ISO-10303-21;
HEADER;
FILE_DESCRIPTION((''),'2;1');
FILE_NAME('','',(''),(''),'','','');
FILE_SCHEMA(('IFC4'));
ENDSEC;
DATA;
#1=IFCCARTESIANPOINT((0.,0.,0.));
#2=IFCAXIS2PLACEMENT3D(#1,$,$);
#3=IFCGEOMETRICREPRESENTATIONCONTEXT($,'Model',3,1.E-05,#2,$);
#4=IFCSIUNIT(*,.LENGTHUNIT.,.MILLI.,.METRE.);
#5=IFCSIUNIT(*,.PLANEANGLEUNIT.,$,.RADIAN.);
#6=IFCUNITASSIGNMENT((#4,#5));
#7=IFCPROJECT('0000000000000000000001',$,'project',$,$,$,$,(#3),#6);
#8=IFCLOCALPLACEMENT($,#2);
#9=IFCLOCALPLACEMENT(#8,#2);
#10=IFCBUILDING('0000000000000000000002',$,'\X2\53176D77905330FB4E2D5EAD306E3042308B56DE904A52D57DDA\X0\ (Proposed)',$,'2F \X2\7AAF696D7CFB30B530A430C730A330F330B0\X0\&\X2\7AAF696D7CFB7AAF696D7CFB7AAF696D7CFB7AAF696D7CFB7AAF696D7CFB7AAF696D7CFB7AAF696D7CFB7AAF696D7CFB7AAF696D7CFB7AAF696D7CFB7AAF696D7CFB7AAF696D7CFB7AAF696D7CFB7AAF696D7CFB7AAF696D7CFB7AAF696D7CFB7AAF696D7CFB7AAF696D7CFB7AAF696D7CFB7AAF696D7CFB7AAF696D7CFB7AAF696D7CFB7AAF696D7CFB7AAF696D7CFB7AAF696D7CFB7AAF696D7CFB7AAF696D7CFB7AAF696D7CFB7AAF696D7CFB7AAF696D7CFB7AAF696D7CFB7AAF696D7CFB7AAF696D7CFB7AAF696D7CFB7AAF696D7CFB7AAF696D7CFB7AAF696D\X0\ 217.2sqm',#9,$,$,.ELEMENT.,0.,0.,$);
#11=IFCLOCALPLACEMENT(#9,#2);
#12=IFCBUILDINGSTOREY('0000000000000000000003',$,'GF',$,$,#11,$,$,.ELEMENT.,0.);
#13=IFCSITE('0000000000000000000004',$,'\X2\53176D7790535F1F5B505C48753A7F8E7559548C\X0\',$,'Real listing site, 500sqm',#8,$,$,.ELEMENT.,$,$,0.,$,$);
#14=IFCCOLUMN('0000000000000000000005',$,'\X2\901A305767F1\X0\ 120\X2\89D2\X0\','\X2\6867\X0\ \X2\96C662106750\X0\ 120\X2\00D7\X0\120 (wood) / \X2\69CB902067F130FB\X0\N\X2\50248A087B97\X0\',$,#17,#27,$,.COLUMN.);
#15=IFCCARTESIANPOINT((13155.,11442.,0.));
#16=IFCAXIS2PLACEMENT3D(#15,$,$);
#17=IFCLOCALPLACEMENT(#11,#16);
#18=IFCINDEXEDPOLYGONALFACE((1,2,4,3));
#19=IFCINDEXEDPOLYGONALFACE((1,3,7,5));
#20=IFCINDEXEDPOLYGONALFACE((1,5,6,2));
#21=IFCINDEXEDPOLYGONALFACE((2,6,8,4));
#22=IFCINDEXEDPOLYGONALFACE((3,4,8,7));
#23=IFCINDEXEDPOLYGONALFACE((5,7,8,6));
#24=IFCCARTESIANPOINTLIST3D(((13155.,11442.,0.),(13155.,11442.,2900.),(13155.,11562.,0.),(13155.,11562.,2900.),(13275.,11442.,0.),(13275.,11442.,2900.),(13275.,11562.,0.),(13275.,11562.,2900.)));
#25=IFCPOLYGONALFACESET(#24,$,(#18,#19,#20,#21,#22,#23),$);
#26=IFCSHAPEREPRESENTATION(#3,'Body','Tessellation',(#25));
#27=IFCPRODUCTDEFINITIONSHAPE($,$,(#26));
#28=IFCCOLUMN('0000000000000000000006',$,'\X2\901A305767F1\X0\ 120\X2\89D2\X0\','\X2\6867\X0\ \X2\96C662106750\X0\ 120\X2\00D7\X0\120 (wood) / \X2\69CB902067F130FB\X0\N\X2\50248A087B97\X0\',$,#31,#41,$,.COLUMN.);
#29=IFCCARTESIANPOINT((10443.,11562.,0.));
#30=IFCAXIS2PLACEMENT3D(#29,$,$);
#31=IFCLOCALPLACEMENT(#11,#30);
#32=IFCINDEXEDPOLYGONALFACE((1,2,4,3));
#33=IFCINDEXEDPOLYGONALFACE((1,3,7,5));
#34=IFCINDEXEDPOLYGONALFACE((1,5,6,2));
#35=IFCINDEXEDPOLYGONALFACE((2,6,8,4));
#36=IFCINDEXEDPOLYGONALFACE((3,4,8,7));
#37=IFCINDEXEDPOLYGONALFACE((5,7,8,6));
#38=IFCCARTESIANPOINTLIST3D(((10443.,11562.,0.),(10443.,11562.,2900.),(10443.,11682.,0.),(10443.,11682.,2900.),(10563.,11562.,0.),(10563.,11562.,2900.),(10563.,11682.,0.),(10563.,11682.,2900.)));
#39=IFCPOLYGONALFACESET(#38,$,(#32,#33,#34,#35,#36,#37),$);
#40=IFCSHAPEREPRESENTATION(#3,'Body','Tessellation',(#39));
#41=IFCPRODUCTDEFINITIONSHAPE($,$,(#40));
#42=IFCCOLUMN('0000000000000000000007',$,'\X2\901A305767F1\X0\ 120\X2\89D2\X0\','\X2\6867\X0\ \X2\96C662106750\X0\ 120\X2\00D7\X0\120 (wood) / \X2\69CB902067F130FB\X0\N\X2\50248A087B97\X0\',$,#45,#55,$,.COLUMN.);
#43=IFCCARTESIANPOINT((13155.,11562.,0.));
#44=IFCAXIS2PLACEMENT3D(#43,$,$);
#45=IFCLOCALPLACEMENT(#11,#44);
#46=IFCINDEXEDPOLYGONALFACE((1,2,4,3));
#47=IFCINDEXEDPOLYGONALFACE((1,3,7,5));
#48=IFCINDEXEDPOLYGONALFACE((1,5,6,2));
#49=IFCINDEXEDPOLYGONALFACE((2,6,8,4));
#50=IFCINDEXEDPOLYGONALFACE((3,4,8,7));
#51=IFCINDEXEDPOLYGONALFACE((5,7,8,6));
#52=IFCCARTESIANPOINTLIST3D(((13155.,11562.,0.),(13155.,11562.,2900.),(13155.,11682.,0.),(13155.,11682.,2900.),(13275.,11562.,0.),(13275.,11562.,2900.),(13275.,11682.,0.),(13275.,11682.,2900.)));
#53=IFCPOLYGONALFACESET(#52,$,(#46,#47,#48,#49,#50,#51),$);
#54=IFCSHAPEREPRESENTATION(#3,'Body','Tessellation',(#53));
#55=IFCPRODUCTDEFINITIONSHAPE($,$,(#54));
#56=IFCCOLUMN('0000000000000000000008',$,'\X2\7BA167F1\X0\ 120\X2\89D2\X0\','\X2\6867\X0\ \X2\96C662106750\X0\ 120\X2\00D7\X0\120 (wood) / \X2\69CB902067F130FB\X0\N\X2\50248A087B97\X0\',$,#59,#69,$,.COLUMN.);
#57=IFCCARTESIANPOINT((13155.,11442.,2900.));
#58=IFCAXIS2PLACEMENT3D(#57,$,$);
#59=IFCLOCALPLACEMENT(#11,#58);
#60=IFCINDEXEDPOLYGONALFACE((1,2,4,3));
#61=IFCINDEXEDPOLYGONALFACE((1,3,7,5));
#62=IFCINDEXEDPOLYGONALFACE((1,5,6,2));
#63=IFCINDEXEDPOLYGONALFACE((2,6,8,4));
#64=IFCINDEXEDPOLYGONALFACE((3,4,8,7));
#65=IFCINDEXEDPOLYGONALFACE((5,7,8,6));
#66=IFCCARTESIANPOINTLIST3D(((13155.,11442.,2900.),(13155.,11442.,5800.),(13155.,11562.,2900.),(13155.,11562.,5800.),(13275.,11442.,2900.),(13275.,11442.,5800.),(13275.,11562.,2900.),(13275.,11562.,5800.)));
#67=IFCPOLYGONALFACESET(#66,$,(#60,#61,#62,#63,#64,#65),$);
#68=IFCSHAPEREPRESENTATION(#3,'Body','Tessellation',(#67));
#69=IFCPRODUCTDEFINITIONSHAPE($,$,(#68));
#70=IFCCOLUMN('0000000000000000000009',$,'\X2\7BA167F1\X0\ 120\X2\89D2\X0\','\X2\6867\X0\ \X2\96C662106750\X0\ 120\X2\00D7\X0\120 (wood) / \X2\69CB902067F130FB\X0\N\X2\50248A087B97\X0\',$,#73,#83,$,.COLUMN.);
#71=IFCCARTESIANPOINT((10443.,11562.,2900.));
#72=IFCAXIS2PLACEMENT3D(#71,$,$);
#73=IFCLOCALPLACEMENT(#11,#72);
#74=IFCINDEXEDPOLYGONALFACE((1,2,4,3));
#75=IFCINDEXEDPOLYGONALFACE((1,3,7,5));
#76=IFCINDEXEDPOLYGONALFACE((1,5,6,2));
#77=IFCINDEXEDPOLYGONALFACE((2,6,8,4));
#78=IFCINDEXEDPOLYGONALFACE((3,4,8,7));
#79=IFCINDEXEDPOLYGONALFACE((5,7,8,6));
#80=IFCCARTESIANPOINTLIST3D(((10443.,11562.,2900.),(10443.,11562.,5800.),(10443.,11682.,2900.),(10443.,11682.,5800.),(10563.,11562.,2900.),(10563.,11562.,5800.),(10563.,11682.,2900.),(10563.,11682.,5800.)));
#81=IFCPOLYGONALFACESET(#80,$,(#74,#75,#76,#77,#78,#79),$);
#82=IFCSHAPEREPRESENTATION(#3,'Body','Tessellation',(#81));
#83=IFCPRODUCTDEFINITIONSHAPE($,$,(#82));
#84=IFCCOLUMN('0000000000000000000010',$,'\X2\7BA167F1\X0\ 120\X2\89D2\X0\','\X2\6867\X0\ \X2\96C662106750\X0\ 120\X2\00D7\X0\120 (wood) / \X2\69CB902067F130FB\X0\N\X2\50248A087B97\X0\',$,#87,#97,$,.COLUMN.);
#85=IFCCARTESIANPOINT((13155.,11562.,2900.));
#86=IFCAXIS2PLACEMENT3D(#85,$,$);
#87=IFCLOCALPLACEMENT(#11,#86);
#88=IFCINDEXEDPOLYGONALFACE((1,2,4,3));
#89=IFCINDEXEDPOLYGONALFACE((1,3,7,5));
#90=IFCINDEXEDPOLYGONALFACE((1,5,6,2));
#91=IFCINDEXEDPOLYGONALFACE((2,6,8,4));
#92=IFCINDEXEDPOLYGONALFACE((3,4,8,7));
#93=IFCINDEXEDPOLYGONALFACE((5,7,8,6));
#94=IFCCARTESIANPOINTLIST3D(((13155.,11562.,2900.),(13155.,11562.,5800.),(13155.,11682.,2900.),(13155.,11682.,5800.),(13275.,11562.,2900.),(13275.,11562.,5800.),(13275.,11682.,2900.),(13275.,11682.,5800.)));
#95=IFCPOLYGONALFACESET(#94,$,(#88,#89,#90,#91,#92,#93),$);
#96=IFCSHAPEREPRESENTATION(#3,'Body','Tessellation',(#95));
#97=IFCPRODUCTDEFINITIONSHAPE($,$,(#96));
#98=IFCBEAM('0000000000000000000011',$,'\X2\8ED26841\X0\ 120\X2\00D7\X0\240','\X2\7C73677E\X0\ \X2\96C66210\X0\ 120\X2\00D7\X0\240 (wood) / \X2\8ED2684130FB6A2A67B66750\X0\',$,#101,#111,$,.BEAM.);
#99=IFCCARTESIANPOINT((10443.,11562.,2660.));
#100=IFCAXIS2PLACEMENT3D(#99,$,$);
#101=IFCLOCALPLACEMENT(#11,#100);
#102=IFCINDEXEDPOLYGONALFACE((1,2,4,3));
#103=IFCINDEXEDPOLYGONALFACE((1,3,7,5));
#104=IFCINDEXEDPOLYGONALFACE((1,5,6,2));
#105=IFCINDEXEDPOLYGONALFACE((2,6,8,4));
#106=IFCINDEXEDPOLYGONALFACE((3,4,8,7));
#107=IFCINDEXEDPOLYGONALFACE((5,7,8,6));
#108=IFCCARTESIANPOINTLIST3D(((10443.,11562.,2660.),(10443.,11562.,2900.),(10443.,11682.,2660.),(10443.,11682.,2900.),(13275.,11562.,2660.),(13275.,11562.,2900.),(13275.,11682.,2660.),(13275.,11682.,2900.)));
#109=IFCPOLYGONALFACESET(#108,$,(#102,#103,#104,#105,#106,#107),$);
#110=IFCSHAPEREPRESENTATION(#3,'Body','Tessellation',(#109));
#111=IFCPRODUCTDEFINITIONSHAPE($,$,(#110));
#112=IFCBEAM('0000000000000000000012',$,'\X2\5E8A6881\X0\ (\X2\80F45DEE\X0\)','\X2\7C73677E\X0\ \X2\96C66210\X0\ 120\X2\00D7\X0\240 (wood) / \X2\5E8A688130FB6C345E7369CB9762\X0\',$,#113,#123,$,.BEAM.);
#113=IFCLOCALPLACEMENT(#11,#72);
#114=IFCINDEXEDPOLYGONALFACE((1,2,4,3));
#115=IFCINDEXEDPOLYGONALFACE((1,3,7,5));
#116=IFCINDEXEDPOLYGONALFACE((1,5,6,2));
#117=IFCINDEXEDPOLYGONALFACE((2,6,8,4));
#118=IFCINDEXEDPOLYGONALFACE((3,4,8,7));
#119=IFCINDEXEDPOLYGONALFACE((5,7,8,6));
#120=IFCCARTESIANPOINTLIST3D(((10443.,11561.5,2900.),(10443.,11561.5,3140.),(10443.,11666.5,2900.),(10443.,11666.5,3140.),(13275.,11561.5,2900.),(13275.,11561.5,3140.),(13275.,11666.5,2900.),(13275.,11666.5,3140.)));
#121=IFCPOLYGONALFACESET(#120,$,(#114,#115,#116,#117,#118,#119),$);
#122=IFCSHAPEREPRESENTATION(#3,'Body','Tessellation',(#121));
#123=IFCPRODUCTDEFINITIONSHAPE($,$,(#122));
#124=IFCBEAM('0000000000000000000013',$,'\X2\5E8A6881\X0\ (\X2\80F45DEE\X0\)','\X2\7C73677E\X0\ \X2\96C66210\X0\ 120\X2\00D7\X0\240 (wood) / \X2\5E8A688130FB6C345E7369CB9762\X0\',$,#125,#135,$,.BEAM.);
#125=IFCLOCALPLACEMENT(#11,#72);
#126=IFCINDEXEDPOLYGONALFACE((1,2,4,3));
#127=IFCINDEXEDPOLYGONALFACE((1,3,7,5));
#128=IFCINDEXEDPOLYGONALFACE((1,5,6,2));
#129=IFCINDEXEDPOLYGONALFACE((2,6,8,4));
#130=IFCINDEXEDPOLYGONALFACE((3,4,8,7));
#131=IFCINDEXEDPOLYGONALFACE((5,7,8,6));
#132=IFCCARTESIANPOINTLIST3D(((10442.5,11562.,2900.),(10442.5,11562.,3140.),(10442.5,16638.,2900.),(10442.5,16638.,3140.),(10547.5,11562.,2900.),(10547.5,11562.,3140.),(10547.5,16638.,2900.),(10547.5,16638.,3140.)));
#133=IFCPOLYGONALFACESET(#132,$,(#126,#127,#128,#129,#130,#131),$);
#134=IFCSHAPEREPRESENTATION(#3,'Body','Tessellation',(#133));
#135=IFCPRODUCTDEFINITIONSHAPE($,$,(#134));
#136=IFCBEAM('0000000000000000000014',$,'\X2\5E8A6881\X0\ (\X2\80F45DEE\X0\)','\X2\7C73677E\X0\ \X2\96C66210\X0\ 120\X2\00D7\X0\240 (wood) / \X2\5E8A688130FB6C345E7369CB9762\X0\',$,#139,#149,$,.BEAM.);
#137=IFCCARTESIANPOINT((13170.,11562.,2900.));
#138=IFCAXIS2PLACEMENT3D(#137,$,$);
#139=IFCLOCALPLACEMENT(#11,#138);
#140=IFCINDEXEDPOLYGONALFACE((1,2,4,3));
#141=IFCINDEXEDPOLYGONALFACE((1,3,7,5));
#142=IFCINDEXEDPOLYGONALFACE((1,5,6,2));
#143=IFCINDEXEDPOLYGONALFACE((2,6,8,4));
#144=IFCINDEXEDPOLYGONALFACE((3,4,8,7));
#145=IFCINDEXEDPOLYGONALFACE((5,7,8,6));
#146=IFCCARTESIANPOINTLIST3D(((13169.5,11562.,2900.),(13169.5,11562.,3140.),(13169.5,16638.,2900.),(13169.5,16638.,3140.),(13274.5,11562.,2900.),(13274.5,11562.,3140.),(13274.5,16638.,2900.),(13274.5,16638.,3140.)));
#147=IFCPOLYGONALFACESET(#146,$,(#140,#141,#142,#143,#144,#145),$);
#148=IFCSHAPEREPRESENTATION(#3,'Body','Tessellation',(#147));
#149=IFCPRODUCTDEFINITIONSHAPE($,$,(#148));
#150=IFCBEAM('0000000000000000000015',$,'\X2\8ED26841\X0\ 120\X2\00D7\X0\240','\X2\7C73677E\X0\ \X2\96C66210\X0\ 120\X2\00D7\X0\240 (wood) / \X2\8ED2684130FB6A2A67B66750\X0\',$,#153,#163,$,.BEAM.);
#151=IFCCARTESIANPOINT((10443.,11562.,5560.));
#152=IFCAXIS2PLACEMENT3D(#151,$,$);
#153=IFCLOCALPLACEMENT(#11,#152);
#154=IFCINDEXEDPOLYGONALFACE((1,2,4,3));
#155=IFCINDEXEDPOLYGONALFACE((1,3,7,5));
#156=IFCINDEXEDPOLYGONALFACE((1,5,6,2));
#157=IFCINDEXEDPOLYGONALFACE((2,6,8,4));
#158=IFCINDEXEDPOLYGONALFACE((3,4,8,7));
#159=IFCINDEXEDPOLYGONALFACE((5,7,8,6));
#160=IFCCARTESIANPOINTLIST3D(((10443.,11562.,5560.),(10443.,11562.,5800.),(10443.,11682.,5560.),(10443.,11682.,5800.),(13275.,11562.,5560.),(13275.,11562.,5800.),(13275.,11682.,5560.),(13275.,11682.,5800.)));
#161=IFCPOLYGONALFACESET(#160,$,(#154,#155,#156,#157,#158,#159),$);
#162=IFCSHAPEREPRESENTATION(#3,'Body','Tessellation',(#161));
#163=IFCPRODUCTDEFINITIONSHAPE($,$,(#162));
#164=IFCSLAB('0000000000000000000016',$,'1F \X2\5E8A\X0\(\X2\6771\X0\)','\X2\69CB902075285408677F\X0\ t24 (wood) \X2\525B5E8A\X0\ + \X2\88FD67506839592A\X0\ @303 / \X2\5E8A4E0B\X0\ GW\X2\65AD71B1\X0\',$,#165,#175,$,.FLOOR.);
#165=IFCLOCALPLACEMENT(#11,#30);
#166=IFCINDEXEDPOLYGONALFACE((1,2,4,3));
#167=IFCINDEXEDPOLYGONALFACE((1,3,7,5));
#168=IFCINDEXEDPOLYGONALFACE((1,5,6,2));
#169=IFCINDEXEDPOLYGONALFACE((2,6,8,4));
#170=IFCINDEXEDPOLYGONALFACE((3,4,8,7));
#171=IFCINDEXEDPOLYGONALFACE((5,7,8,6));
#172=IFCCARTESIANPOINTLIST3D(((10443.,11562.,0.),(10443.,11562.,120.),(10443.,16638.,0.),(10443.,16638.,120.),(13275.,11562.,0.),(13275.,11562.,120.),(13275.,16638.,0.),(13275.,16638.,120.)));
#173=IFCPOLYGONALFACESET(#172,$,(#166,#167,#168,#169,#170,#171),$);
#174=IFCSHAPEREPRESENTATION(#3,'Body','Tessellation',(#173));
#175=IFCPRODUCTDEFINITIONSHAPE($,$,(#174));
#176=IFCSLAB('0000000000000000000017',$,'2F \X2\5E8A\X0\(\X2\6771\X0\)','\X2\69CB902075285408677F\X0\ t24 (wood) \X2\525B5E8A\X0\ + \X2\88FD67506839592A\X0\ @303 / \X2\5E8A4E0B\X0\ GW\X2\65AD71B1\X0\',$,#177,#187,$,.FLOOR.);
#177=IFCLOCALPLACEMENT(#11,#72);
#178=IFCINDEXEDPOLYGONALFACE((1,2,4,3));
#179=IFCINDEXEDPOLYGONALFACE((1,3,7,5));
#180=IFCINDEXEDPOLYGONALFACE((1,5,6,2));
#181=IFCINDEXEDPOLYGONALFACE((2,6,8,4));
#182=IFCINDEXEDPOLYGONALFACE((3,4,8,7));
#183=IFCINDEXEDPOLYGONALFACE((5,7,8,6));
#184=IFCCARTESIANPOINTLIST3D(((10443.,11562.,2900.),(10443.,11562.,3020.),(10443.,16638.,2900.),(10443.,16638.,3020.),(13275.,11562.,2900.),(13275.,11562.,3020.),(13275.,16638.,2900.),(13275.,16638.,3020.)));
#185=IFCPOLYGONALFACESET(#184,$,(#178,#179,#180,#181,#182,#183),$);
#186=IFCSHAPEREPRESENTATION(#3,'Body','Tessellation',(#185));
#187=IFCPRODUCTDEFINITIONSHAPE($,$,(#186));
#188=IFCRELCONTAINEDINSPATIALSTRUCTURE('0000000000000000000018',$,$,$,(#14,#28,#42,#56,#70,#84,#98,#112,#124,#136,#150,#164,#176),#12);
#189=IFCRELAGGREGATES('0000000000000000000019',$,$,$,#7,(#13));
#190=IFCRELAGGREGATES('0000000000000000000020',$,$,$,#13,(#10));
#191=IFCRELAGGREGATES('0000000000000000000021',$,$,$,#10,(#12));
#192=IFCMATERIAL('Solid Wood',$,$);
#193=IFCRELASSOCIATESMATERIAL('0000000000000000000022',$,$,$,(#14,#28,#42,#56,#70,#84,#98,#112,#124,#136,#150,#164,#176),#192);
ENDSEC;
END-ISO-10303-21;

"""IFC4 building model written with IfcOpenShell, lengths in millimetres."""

from ifc_helpers import new_model, si_unit, frame, frame_2d, origin, place, context, project, spatial, rectangle, extrude, material, element, save


model = new_model("IFC4")

# Units and contexts
model_context = context("Model", 3, precision=1e-05, world=origin())
ifc_project = project(units=[si_unit("LENGTHUNIT", "METRE", prefix="MILLI"), si_unit("PLANEANGLEUNIT", "RADIAN")], contexts=[model_context])

# Site, building, storey
site_placement = place(None, origin())
site = spatial("IfcSite", under=ifc_project, at=site_placement, Name="北海道弟子屈町美留和", ObjectType="Real listing site, 500sqm", CompositionType="ELEMENT", RefElevation=0.0)
building_placement = place(site_placement, origin())
building = spatial("IfcBuilding", under=site, at=building_placement, Name="北海道・中庭のある回遊動線 (Proposed)", ObjectType="2F 窯業系サイディング&窯業系窯業系窯業系窯業系窯業系窯業系窯業系窯業系窯業系窯業系窯業系窯業系窯業系窯業系窯業系窯業系窯業系窯業系窯業系窯業系窯業系窯業系窯業系窯業系窯業系窯業系窯業系窯業系窯業系窯業系窯業系窯業系窯業系窯業系窯業系窯業系窯業 217.2sqm", CompositionType="ELEMENT", ElevationOfRefHeight=0.0, ElevationOfTerrain=0.0)
storey_placement = place(building_placement, origin())
storey = spatial("IfcBuildingStorey", under=building, at=storey_placement, Name="GF", CompositionType="ELEMENT", Elevation=0.0)

# Columns
ifc_material_1 = material(Name="Solid Wood")
column_1_placement = place(storey_placement, frame((13155.0, 11442.0, 0.0)))
element("IfcColumn", 1, at=column_1_placement, inside=storey, material=ifc_material_1, Name="通し柱 120角", Description="桧 集成材 120×120 (wood) / 構造柱・N値計算", PredefinedType="COLUMN", context=model_context, shape_type="SweptSolid", body=[
    extrude(rectangle(XDim=120.0, YDim=120.0, at=frame_2d((60.0, 60.0))), frame((13155.0, 11442.0, 0.0)), (0.0, 0.0, 1.0), 2900.0),
])
column_2_placement = place(storey_placement, frame((10443.0, 11562.0, 0.0)))
element("IfcColumn", 2, at=column_2_placement, inside=storey, material=ifc_material_1, Name="通し柱 120角", Description="桧 集成材 120×120 (wood) / 構造柱・N値計算", PredefinedType="COLUMN", context=model_context, shape_type="SweptSolid", body=[
    extrude(rectangle(XDim=120.0, YDim=120.0, at=frame_2d((60.0, 60.0))), frame((10443.0, 11562.0, 0.0)), (0.0, 0.0, 1.0), 2900.0),
])
column_3_placement = place(storey_placement, frame((13155.0, 11562.0, 0.0)))
element("IfcColumn", 3, at=column_3_placement, inside=storey, material=ifc_material_1, Name="通し柱 120角", Description="桧 集成材 120×120 (wood) / 構造柱・N値計算", PredefinedType="COLUMN", context=model_context, shape_type="SweptSolid", body=[
    extrude(rectangle(XDim=120.0, YDim=120.0, at=frame_2d((60.0, 60.0))), frame((13155.0, 11562.0, 0.0)), (0.0, 0.0, 1.0), 2900.0),
])
column_4_placement = place(storey_placement, frame((13155.0, 11442.0, 2900.0)))
element("IfcColumn", 4, at=column_4_placement, inside=storey, material=ifc_material_1, Name="管柱 120角", Description="桧 集成材 120×120 (wood) / 構造柱・N値計算", PredefinedType="COLUMN", context=model_context, shape_type="SweptSolid", body=[
    extrude(rectangle(XDim=120.0, YDim=120.0, at=frame_2d((60.0, 60.0))), frame((13155.0, 11442.0, 2900.0)), (0.0, 0.0, 1.0), 2900.0),
])
column_5_placement = place(storey_placement, frame((10443.0, 11562.0, 2900.0)))
element("IfcColumn", 5, at=column_5_placement, inside=storey, material=ifc_material_1, Name="管柱 120角", Description="桧 集成材 120×120 (wood) / 構造柱・N値計算", PredefinedType="COLUMN", context=model_context, shape_type="SweptSolid", body=[
    extrude(rectangle(XDim=120.0, YDim=120.0, at=frame_2d((60.0, 60.0))), frame((10443.0, 11562.0, 2900.0)), (0.0, 0.0, 1.0), 2900.0),
])
column_6_placement = place(storey_placement, frame((13155.0, 11562.0, 2900.0)))
element("IfcColumn", 6, at=column_6_placement, inside=storey, material=ifc_material_1, Name="管柱 120角", Description="桧 集成材 120×120 (wood) / 構造柱・N値計算", PredefinedType="COLUMN", context=model_context, shape_type="SweptSolid", body=[
    extrude(rectangle(XDim=120.0, YDim=120.0, at=frame_2d((60.0, 60.0))), frame((13155.0, 11562.0, 2900.0)), (0.0, 0.0, 1.0), 2900.0),
])

# Beams
beam_1_placement = place(storey_placement, frame((10443.0, 11562.0, 2660.0)))
element("IfcBeam", 7, at=beam_1_placement, inside=storey, material=ifc_material_1, Name="軒桁 120×240", Description="米松 集成 120×240 (wood) / 軒桁・横架材", PredefinedType="BEAM", context=model_context, shape_type="SweptSolid", body=[
    extrude(rectangle(XDim=2832.0, YDim=120.0, at=frame_2d((1416.0, 60.0))), frame((10443.0, 11562.0, 2660.0)), (0.0, 0.0, 1.0), 240.0),
])
beam_2_placement = place(storey_placement, frame((10443.0, 11562.0, 2900.0)))
element("IfcBeam", 8, at=beam_2_placement, inside=storey, material=ifc_material_1, Name="床梁 (胴差)", Description="米松 集成 120×240 (wood) / 床梁・水平構面", PredefinedType="BEAM", context=model_context, shape_type="SweptSolid", body=[
    extrude(rectangle(XDim=2832.0, YDim=105.0, at=frame_2d((1416.0, 52.0))), frame((10443.0, 11562.0, 2900.0)), (0.0, 0.0, 1.0), 240.0),
])
beam_3_placement = place(storey_placement, frame((10443.0, 11562.0, 2900.0)))
element("IfcBeam", 9, at=beam_3_placement, inside=storey, material=ifc_material_1, Name="床梁 (胴差)", Description="米松 集成 120×240 (wood) / 床梁・水平構面", PredefinedType="BEAM", context=model_context, shape_type="SweptSolid", body=[
    extrude(rectangle(XDim=105.0, YDim=5076.0, at=frame_2d((52.0, 2538.0))), frame((10443.0, 11562.0, 2900.0)), (0.0, 0.0, 1.0), 240.0),
])
beam_4_placement = place(storey_placement, frame((13170.0, 11562.0, 2900.0)))
element("IfcBeam", 10, at=beam_4_placement, inside=storey, material=ifc_material_1, Name="床梁 (胴差)", Description="米松 集成 120×240 (wood) / 床梁・水平構面", PredefinedType="BEAM", context=model_context, shape_type="SweptSolid", body=[
    extrude(rectangle(XDim=105.0, YDim=5076.0, at=frame_2d((52.0, 2538.0))), frame((13170.0, 11562.0, 2900.0)), (0.0, 0.0, 1.0), 240.0),
])
beam_5_placement = place(storey_placement, frame((10443.0, 11562.0, 5560.0)))
element("IfcBeam", 11, at=beam_5_placement, inside=storey, material=ifc_material_1, Name="軒桁 120×240", Description="米松 集成 120×240 (wood) / 軒桁・横架材", PredefinedType="BEAM", context=model_context, shape_type="SweptSolid", body=[
    extrude(rectangle(XDim=2832.0, YDim=120.0, at=frame_2d((1416.0, 60.0))), frame((10443.0, 11562.0, 5560.0)), (0.0, 0.0, 1.0), 240.0),
])

# Slabs
slab_1_placement = place(storey_placement, frame((10443.0, 11562.0, 0.0)))
element("IfcSlab", 12, at=slab_1_placement, inside=storey, material=ifc_material_1, Name="1F 床(東)", Description="構造用合板 t24 (wood) 剛床 + 製材根太 @303 / 床下 GW断熱", PredefinedType="FLOOR", context=model_context, shape_type="SweptSolid", body=[
    extrude(rectangle(XDim=2832.0, YDim=5076.0, at=frame_2d((1416.0, 2538.0))), frame((10443.0, 11562.0, 0.0)), (0.0, 0.0, 1.0), 120.0),
])
slab_2_placement = place(storey_placement, frame((10443.0, 11562.0, 2900.0)))
element("IfcSlab", 13, at=slab_2_placement, inside=storey, material=ifc_material_1, Name="2F 床(東)", Description="構造用合板 t24 (wood) 剛床 + 製材根太 @303 / 床下 GW断熱", PredefinedType="FLOOR", context=model_context, shape_type="SweptSolid", body=[
    extrude(rectangle(XDim=2832.0, YDim=5076.0, at=frame_2d((1416.0, 2538.0))), frame((10443.0, 11562.0, 2900.0)), (0.0, 0.0, 1.0), 120.0),
])

save(model, "model.ifc")
